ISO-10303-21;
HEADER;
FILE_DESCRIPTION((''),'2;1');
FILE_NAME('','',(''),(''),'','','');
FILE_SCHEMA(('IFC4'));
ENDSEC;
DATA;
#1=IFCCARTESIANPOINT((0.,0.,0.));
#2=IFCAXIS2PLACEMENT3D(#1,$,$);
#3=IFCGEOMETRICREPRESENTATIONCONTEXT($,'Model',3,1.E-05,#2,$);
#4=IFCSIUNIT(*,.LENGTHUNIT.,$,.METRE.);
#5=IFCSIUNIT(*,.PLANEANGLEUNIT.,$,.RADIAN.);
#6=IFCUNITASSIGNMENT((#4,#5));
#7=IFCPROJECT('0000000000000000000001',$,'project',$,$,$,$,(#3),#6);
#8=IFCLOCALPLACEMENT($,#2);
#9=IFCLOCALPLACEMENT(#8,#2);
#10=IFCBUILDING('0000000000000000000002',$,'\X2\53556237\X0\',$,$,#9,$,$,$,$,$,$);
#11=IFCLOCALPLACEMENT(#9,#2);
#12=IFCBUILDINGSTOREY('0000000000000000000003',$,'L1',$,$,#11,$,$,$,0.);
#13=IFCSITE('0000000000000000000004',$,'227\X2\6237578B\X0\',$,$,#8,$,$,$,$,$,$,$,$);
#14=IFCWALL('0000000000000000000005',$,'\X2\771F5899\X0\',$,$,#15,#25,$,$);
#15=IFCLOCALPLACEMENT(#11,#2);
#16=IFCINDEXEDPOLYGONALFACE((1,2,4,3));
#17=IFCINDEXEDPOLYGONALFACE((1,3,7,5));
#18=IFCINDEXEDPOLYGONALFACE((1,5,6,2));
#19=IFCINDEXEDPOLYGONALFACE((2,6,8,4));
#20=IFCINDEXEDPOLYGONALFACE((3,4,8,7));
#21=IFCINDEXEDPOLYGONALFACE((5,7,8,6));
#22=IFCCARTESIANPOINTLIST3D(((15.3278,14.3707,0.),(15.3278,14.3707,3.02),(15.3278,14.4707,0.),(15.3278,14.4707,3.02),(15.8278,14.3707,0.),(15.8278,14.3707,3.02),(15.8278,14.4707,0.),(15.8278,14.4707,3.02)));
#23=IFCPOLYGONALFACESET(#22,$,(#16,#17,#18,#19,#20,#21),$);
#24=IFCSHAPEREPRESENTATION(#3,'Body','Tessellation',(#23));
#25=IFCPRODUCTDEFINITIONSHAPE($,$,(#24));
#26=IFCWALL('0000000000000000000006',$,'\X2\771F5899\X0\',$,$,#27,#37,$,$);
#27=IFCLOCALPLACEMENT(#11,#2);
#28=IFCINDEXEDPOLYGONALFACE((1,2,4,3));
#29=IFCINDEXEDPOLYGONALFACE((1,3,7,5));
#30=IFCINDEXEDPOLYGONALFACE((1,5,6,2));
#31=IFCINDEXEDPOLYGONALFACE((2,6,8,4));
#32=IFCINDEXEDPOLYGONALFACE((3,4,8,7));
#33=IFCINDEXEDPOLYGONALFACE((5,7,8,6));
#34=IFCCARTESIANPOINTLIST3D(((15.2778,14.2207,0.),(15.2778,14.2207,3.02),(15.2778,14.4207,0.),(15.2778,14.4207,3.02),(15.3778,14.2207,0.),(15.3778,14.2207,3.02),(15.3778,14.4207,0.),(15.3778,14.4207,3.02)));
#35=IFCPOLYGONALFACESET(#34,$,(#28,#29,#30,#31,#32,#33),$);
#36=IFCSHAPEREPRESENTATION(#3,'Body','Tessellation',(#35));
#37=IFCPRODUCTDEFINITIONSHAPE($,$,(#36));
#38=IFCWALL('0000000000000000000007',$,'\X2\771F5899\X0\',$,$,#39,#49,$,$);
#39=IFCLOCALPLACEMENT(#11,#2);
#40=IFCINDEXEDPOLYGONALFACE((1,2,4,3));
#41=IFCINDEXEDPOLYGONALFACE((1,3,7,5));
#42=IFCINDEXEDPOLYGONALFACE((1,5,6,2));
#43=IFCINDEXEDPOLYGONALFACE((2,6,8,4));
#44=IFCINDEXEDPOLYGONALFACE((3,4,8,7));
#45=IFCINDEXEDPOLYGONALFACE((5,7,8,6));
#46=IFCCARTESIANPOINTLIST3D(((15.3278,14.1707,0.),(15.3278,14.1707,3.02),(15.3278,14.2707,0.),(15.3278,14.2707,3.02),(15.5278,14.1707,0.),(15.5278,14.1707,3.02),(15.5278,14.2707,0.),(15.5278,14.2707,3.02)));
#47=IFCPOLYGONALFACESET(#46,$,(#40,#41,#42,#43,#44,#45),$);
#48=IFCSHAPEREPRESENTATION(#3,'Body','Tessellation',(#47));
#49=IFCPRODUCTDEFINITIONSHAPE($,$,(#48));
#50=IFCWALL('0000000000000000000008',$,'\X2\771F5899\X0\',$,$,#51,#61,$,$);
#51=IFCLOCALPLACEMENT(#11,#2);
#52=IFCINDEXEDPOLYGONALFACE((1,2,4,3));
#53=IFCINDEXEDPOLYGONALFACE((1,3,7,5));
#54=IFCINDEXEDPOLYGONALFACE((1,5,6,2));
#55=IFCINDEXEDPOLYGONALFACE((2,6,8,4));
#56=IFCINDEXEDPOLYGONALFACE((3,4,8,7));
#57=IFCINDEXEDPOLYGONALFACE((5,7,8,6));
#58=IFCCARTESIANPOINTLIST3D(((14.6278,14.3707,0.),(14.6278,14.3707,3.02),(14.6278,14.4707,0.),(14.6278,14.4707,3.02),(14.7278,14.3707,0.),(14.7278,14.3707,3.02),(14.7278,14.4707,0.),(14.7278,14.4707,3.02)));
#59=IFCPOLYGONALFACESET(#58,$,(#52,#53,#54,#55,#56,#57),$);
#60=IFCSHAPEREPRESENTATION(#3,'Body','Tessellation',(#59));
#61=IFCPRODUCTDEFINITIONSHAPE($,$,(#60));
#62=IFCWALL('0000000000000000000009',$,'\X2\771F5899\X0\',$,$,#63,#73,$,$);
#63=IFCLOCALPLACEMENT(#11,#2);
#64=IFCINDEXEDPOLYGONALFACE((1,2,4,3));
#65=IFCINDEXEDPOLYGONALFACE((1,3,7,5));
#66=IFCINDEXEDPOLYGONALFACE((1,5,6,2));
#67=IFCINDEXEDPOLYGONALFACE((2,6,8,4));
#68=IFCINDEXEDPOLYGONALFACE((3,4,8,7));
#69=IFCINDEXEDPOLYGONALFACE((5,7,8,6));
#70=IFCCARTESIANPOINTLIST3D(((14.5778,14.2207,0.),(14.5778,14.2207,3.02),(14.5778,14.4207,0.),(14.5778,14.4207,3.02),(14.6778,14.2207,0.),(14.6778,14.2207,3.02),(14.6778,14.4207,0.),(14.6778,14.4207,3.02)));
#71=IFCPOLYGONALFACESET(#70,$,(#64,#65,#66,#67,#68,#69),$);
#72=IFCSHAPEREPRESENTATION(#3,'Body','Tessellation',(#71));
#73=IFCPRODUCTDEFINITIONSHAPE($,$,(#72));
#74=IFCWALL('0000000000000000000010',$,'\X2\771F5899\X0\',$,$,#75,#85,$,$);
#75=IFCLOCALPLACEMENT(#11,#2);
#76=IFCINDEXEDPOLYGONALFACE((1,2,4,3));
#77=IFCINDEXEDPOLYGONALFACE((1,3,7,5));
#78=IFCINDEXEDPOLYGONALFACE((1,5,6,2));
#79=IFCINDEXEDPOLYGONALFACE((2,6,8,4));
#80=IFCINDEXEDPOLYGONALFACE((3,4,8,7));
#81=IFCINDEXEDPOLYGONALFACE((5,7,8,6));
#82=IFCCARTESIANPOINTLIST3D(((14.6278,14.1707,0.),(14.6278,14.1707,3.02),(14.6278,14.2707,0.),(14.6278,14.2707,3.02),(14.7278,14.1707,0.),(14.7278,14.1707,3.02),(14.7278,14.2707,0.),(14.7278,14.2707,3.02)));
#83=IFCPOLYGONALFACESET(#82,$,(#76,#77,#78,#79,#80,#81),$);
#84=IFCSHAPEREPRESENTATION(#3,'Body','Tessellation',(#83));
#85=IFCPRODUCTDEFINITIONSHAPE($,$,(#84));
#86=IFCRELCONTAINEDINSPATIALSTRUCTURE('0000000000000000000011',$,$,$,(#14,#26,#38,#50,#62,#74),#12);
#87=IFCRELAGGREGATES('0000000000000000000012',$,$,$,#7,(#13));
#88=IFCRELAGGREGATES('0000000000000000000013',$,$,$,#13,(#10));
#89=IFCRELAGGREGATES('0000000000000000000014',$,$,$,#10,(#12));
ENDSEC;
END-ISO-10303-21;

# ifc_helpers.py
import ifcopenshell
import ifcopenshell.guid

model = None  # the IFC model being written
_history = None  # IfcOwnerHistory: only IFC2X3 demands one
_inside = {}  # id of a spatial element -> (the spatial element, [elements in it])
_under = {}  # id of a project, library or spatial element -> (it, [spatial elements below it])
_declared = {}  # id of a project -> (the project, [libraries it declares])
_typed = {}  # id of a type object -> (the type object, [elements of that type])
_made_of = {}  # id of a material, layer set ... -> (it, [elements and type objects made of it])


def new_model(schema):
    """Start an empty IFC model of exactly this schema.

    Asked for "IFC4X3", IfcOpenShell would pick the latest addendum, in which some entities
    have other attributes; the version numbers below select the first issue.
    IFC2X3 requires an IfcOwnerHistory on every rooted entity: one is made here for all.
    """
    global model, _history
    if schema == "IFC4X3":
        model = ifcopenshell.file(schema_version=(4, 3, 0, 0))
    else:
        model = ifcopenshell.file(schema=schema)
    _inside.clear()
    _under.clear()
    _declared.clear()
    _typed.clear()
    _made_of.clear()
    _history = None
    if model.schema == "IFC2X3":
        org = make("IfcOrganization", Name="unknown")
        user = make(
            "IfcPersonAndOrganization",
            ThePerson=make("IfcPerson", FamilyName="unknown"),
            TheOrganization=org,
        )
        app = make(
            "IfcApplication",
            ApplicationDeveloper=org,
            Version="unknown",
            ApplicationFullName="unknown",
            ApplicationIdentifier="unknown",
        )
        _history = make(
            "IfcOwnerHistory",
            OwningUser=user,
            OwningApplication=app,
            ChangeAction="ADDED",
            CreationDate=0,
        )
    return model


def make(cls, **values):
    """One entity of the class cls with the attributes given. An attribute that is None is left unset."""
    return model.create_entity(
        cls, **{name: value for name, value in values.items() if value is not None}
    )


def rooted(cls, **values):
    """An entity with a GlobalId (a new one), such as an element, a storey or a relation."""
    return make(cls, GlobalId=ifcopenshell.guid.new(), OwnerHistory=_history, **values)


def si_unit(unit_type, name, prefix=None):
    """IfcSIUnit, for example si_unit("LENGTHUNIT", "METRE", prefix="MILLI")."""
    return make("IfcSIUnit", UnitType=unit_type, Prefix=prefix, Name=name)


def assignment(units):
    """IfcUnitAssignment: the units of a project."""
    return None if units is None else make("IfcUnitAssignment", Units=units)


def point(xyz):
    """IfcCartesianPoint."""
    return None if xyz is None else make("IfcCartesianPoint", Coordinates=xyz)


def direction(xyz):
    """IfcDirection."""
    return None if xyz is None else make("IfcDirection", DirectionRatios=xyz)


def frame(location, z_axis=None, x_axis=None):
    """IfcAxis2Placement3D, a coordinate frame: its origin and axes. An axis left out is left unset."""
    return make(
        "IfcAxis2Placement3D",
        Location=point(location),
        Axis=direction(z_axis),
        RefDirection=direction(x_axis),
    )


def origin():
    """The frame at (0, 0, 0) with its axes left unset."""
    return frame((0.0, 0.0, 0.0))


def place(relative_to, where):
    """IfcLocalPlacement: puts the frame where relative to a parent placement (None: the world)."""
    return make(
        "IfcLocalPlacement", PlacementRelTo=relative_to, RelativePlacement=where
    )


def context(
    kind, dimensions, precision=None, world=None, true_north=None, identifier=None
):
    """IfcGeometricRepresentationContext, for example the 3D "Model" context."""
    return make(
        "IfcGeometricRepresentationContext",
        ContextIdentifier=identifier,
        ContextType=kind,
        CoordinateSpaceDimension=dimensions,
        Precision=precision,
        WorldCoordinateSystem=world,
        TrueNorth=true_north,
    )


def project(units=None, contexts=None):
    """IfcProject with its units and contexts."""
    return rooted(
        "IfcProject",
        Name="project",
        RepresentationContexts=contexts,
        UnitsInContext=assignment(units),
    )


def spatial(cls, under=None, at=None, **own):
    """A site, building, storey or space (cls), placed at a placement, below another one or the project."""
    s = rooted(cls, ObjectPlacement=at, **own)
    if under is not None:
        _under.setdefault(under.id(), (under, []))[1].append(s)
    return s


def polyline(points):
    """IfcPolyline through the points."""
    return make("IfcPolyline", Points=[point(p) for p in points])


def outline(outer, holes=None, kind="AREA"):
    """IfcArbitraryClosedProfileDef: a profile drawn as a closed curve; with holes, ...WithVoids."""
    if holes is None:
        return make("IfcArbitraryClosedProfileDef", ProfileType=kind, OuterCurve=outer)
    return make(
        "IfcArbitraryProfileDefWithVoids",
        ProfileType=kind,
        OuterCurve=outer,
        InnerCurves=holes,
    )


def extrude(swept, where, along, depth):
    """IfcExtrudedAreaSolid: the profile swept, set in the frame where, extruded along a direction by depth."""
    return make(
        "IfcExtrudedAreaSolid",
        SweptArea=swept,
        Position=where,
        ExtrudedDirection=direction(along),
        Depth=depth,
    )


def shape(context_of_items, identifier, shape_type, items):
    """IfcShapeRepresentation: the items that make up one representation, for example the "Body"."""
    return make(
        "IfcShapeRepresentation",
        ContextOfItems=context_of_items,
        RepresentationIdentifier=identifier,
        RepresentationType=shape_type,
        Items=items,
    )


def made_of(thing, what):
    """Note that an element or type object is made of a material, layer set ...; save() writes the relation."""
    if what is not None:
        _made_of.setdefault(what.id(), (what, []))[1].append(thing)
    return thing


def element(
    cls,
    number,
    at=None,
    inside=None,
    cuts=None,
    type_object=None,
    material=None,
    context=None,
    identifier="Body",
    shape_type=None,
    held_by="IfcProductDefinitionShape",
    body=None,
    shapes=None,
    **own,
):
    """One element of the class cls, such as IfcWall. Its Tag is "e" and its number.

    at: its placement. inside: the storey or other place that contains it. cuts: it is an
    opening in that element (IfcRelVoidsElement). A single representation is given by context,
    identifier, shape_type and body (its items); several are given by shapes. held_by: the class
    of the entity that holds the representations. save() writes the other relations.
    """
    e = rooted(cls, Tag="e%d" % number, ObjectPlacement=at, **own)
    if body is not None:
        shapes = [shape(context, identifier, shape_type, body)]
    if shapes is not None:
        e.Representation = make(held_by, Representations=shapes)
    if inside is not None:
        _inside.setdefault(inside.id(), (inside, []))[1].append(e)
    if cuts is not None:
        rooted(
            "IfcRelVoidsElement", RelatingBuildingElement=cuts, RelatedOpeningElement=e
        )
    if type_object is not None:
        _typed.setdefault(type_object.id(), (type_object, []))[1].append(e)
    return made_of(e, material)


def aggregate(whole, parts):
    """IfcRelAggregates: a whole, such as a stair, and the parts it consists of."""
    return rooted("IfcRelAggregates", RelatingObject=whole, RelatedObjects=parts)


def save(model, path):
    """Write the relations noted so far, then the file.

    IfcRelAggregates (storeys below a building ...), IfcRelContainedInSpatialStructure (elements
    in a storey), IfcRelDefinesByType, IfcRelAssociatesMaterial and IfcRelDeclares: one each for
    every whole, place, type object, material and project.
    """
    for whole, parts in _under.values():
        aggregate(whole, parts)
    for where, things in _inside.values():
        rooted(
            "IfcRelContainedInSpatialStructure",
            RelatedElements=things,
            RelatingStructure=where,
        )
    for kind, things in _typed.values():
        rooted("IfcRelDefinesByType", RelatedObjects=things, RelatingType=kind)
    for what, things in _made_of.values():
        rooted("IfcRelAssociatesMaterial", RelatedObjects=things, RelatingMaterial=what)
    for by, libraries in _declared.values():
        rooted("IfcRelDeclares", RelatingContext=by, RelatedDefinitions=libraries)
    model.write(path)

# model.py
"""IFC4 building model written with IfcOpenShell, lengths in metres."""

from ifc_helpers import new_model, si_unit, origin, place, context, project, spatial, polyline, outline, extrude, element, save


model = new_model("IFC4")

# Units and contexts
model_context = context("Model", 3, precision=1e-05, world=origin())
ifc_project = project(units=[si_unit("LENGTHUNIT", "METRE"), si_unit("PLANEANGLEUNIT", "RADIAN")], contexts=[model_context])

# Site, building, storey
site_placement = place(None, origin())
site = spatial("IfcSite", under=ifc_project, at=site_placement, Name="227户型")
building_placement = place(site_placement, origin())
building = spatial("IfcBuilding", under=site, at=building_placement, Name="单户")
storey_placement = place(building_placement, origin())
storey = spatial("IfcBuildingStorey", under=building, at=storey_placement, Name="L1", Elevation=0.0)

# Walls
wall_1_placement = place(storey_placement, origin())
element("IfcWall", 1, at=wall_1_placement, inside=storey, Name="真墙", context=model_context, shape_type="SweptSolid", body=[
    extrude(outline(polyline([(15.8278, 14.3707), (15.3278, 14.3707), (15.3278, 14.4707), (15.8278, 14.4707), (15.8278, 14.3707)])), origin(), (0.0, 0.0, 1.0), 3.02),
])
wall_2_placement = place(storey_placement, origin())
element("IfcWall", 2, at=wall_2_placement, inside=storey, Name="真墙", context=model_context, shape_type="SweptSolid", body=[
    extrude(outline(polyline([(15.3778, 14.4207), (15.3778, 14.2207), (15.2778, 14.2207), (15.2778, 14.4207), (15.3778, 14.4207)])), origin(), (0.0, 0.0, 1.0), 3.02),
])
wall_3_placement = place(storey_placement, origin())
element("IfcWall", 3, at=wall_3_placement, inside=storey, Name="真墙", context=model_context, shape_type="SweptSolid", body=[
    extrude(outline(polyline([(15.3278, 14.2707), (15.5278, 14.2707), (15.5278, 14.1707), (15.3278, 14.1707), (15.3278, 14.2707)])), origin(), (0.0, 0.0, 1.0), 3.02),
])
wall_4_placement = place(storey_placement, origin())
element("IfcWall", 4, at=wall_4_placement, inside=storey, Name="真墙", context=model_context, shape_type="SweptSolid", body=[
    extrude(outline(polyline([(14.7278, 14.3707), (14.6278, 14.3707), (14.6278, 14.4707), (14.7278, 14.4707), (14.7278, 14.3707)])), origin(), (0.0, 0.0, 1.0), 3.02),
])
wall_5_placement = place(storey_placement, origin())
element("IfcWall", 5, at=wall_5_placement, inside=storey, Name="真墙", context=model_context, shape_type="SweptSolid", body=[
    extrude(outline(polyline([(14.6778, 14.4207), (14.6778, 14.2207), (14.5778, 14.2207), (14.5778, 14.4207), (14.6778, 14.4207)])), origin(), (0.0, 0.0, 1.0), 3.02),
])
wall_6_placement = place(storey_placement, origin())
element("IfcWall", 6, at=wall_6_placement, inside=storey, Name="真墙", context=model_context, shape_type="SweptSolid", body=[
    extrude(outline(polyline([(14.6278, 14.2707), (14.7278, 14.2707), (14.7278, 14.1707), (14.6278, 14.1707), (14.6278, 14.2707)])), origin(), (0.0, 0.0, 1.0), 3.02),
])

save(model, "model.ifc")
